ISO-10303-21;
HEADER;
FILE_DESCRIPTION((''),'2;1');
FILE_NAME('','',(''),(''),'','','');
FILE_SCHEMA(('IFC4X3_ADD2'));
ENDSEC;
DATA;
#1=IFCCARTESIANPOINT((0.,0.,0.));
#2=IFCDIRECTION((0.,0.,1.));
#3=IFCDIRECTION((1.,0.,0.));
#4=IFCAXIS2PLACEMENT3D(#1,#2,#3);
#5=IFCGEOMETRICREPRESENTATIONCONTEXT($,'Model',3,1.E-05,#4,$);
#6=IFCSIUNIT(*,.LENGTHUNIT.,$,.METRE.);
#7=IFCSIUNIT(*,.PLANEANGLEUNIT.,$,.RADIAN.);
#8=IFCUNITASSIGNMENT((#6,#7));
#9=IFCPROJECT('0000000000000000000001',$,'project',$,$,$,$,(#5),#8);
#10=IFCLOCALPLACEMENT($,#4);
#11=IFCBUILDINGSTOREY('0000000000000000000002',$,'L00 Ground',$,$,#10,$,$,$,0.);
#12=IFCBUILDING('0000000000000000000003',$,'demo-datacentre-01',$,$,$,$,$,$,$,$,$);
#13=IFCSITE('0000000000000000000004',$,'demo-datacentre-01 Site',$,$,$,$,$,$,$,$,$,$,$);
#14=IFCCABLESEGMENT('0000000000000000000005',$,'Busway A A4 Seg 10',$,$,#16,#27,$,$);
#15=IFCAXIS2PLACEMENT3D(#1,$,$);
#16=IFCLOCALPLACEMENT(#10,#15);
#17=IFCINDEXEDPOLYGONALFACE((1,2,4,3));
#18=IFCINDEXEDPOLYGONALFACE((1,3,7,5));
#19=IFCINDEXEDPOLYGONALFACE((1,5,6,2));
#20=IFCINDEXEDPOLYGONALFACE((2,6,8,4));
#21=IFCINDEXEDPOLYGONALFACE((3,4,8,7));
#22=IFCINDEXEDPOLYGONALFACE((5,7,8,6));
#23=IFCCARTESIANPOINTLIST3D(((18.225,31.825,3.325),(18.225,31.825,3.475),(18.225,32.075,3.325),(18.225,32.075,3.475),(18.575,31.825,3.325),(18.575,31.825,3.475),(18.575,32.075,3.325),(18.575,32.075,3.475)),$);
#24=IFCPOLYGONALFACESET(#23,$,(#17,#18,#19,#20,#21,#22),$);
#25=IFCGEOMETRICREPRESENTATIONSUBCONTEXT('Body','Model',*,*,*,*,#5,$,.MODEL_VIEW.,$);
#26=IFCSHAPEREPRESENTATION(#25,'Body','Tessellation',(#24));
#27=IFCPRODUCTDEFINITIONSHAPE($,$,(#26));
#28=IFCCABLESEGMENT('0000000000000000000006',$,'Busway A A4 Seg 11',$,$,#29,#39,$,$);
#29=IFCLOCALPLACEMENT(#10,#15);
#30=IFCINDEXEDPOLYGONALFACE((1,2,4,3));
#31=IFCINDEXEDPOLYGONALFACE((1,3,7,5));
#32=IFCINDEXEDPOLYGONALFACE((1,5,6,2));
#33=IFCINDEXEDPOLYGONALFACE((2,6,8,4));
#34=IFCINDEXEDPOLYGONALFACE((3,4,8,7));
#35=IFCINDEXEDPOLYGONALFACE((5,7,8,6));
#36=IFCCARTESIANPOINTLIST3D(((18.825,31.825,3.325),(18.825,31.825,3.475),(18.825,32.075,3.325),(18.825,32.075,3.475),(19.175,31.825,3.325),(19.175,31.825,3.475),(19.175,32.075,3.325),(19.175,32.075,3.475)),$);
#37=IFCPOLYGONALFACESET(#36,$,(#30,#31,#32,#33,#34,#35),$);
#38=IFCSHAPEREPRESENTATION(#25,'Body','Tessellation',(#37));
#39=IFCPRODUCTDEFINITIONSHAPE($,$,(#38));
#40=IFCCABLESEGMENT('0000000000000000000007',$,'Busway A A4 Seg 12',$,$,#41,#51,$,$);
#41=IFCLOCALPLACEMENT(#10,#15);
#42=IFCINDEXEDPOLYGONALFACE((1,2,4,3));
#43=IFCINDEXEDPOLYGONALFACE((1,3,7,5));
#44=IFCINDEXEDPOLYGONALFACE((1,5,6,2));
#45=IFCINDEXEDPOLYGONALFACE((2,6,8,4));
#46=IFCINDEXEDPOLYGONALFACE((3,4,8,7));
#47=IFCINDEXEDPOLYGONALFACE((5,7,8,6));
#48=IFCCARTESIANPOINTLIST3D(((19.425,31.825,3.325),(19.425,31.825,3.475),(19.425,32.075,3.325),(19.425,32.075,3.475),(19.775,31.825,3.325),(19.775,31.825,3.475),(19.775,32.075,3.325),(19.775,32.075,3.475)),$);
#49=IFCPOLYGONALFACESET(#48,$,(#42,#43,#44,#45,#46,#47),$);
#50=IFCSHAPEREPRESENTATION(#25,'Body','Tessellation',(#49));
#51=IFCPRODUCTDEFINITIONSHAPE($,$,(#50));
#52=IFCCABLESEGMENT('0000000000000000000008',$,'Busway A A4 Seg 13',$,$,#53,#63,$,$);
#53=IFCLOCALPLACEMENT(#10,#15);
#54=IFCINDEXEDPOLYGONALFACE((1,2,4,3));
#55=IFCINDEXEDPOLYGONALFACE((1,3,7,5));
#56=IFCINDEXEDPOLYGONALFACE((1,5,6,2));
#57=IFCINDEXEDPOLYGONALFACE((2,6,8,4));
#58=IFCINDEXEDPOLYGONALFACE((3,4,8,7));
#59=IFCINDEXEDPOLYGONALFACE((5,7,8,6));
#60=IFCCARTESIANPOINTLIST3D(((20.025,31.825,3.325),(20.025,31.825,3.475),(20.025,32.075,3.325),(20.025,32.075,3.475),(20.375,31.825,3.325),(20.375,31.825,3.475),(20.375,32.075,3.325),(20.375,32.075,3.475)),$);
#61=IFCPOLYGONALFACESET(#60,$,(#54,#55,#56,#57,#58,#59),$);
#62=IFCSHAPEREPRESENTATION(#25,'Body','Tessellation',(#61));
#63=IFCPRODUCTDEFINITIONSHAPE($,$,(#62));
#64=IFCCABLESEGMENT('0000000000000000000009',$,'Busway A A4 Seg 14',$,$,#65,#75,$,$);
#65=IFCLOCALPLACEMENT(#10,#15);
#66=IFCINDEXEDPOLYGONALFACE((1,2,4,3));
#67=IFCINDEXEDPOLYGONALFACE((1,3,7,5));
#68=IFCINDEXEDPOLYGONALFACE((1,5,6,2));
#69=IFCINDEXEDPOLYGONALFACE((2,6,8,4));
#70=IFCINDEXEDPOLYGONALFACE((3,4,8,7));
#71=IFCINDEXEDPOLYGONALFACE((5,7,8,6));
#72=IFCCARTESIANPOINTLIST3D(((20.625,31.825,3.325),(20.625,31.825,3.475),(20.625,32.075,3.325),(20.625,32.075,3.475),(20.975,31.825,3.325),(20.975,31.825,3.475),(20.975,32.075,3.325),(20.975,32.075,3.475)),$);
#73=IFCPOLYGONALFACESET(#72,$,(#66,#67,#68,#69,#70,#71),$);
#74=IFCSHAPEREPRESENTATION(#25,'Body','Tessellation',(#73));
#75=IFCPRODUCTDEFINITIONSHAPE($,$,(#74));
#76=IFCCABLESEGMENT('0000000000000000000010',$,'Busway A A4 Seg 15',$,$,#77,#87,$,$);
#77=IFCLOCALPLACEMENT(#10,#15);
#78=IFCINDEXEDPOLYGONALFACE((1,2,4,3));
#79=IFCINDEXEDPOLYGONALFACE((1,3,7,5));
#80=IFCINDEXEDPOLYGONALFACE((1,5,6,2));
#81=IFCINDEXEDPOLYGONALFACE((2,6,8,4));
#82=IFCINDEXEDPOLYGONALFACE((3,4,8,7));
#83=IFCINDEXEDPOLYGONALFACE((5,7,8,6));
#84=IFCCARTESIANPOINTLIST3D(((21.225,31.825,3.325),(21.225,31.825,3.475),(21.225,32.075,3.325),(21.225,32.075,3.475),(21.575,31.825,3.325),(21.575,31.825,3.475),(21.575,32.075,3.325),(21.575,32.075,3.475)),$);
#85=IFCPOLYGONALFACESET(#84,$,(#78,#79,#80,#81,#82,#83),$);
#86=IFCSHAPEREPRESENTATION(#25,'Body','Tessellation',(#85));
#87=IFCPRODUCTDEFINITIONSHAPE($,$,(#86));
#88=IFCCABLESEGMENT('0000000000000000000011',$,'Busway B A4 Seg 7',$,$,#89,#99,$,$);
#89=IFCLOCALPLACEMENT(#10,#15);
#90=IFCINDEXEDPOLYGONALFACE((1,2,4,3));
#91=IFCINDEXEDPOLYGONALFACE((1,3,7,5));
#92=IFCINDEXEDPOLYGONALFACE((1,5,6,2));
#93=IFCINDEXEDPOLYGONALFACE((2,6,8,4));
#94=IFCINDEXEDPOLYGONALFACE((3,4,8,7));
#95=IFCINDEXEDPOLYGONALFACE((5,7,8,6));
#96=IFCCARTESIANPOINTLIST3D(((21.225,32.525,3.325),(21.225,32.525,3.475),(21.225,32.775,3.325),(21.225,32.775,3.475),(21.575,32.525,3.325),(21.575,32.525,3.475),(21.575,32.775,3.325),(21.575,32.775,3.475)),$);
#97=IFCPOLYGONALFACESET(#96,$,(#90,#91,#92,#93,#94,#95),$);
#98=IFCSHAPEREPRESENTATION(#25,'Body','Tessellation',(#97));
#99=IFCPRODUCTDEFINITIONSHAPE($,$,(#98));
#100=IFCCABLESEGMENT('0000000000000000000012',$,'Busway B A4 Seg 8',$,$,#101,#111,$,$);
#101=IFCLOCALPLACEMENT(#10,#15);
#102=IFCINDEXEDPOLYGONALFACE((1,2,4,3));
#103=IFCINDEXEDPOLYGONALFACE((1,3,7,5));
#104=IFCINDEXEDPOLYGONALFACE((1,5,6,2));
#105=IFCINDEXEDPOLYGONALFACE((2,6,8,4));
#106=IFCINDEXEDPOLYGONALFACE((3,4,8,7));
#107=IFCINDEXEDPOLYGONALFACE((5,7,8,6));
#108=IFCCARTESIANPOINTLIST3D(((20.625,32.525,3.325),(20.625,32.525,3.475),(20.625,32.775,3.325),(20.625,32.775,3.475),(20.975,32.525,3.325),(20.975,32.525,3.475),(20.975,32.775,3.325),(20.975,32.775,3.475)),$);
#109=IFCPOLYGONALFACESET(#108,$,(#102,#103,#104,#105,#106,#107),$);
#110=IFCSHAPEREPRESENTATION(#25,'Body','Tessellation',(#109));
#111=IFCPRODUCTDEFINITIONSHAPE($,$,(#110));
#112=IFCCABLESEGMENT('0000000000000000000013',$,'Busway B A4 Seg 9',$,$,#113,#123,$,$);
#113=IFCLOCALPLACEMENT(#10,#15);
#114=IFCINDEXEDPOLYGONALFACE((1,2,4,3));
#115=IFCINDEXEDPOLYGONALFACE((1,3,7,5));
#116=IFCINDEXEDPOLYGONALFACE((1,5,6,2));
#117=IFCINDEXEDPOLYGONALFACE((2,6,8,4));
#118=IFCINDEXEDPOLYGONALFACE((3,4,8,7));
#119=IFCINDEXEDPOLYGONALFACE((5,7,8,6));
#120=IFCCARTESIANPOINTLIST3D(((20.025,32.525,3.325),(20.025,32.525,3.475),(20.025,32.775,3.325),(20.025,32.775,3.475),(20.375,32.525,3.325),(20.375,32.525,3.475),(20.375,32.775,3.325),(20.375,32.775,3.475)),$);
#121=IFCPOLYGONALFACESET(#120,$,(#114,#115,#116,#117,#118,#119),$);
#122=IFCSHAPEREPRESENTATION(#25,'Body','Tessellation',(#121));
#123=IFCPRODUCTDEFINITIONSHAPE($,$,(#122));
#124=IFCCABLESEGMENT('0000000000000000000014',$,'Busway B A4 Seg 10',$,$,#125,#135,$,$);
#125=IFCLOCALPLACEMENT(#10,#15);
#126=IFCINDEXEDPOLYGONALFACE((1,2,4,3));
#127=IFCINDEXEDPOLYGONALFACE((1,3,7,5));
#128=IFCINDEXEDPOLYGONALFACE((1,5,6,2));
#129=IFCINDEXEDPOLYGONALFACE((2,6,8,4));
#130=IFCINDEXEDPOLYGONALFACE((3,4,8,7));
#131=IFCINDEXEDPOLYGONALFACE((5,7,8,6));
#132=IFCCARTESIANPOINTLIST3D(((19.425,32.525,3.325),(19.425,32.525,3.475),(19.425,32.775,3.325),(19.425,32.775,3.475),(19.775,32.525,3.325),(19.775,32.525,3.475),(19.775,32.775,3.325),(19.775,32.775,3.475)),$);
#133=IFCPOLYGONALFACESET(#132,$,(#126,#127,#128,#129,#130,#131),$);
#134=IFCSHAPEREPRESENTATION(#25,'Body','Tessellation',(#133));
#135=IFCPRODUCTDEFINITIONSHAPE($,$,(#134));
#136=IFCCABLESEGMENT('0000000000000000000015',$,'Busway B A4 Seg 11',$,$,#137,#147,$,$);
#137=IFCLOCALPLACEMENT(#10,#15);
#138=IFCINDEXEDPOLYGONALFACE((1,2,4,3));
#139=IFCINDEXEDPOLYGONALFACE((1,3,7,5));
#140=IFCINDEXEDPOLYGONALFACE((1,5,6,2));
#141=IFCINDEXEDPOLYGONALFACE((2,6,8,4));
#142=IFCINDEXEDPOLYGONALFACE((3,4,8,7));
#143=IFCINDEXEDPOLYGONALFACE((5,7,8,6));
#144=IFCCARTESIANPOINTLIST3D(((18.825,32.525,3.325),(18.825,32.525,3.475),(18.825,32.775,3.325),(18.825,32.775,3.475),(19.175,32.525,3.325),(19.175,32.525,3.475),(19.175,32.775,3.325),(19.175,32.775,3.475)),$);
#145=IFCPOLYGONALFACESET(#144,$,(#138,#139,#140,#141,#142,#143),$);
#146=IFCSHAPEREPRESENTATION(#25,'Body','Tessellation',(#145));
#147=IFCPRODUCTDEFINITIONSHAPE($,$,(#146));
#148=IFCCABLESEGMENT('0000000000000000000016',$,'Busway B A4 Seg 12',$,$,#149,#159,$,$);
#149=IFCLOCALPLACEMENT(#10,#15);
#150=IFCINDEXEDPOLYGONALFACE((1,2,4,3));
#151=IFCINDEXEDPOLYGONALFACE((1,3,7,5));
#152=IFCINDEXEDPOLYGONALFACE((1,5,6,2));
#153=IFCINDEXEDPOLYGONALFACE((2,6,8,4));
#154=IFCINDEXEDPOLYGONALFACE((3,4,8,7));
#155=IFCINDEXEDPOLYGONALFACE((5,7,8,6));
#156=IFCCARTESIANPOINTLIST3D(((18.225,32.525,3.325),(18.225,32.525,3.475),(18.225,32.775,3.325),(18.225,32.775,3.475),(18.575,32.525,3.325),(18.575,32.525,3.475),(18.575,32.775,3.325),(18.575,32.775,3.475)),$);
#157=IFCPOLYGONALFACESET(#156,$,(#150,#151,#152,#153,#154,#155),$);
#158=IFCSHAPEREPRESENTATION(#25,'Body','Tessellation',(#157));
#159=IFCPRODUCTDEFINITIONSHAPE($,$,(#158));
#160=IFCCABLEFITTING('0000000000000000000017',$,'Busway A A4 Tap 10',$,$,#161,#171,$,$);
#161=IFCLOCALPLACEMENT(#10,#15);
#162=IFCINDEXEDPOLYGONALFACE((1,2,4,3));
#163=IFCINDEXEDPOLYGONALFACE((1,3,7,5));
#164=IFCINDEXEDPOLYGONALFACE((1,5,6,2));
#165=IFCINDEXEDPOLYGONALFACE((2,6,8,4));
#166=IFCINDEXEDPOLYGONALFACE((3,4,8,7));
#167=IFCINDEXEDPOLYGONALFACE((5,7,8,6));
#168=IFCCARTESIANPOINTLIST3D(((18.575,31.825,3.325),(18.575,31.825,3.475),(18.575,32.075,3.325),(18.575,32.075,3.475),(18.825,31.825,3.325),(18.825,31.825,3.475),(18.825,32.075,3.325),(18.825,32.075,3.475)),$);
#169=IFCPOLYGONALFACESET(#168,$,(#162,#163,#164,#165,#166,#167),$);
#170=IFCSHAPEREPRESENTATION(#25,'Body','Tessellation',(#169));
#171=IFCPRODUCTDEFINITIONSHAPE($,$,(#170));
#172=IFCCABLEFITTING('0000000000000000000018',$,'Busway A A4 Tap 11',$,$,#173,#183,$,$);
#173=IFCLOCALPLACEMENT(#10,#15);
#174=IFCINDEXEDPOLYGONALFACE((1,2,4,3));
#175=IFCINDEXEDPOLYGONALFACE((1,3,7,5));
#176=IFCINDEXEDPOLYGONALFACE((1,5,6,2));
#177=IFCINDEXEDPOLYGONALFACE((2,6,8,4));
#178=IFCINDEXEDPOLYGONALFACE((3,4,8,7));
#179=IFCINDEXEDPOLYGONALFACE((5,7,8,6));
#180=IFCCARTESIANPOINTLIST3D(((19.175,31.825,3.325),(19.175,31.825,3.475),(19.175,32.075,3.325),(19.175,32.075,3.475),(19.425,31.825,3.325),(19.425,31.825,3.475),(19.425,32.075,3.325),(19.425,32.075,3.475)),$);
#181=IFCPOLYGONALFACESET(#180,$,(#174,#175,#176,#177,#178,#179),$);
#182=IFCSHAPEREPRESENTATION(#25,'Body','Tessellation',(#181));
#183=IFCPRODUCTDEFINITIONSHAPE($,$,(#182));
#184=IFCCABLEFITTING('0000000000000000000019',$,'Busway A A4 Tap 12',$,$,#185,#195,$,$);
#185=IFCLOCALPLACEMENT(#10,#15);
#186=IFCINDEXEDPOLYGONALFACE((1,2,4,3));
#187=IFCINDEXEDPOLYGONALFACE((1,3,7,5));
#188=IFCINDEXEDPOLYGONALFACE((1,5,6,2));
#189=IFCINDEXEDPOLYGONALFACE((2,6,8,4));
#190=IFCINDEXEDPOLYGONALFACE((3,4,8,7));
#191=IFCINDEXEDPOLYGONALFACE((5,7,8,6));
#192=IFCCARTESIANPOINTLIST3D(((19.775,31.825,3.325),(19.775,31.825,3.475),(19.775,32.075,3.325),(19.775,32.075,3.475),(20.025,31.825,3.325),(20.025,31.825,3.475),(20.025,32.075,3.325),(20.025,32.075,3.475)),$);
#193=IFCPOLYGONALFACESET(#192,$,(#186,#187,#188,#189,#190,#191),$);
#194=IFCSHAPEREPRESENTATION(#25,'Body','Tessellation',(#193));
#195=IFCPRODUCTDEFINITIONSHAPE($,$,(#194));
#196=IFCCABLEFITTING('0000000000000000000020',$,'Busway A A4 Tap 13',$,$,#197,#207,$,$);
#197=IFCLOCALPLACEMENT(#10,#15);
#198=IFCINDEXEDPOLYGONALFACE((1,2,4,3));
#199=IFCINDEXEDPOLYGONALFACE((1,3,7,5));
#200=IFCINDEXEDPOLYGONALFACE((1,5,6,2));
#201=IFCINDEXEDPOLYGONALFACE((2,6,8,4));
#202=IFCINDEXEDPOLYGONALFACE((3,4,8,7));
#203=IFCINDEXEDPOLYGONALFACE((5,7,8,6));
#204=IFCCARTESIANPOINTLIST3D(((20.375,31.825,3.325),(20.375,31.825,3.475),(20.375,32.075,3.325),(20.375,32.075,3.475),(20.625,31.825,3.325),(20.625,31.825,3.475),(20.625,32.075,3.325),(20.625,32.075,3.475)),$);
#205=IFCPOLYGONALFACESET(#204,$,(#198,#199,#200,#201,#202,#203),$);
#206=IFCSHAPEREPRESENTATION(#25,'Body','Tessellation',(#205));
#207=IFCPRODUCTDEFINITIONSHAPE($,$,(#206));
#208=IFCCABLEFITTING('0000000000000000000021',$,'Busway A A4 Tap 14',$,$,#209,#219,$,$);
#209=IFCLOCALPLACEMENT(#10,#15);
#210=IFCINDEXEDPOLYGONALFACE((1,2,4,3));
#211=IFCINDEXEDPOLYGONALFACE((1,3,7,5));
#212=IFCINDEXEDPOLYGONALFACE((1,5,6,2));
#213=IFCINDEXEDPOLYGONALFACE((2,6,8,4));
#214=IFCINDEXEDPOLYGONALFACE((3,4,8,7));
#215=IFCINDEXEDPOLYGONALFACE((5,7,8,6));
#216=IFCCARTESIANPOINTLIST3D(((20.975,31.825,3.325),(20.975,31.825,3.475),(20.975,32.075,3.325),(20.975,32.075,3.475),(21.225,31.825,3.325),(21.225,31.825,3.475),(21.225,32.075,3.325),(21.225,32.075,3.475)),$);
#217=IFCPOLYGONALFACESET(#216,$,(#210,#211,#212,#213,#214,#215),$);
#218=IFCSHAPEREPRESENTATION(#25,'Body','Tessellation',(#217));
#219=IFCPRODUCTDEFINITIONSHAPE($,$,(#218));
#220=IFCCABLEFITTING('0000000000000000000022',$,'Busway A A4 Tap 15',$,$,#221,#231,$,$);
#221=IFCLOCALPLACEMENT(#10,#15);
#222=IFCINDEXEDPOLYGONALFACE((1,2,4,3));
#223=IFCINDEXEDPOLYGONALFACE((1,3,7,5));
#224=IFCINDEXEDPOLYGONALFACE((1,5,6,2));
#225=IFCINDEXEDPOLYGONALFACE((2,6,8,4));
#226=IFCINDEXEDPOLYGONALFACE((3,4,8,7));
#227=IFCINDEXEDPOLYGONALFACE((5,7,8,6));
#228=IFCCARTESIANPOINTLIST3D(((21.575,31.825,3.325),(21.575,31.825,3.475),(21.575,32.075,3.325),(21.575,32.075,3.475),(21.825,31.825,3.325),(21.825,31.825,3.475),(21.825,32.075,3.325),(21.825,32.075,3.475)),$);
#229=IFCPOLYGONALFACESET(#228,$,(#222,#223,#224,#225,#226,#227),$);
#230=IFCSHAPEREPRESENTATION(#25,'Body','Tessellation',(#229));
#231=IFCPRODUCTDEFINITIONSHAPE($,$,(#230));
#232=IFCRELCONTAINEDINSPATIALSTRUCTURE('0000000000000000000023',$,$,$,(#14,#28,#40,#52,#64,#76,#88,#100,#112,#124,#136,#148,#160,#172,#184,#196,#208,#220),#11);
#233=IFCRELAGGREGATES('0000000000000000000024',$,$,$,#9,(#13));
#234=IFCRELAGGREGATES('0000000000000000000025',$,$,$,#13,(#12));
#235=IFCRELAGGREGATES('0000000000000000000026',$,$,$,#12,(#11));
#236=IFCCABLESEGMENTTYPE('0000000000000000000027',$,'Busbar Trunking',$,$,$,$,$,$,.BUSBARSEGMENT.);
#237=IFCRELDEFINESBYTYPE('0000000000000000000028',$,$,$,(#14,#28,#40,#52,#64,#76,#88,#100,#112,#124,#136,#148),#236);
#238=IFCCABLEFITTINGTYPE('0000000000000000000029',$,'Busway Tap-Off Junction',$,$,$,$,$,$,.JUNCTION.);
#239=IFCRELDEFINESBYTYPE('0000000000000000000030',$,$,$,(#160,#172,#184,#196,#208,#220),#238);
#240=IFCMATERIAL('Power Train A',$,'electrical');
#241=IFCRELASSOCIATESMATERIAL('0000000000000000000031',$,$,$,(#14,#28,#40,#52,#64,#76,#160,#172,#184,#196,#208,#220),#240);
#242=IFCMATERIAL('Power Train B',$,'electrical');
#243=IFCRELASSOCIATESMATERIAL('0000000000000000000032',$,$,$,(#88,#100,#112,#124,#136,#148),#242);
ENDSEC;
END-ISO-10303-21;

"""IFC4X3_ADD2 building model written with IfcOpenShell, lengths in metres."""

from ifc_helpers import new_model, si_unit, frame, origin_with_axes, place, context, subcontext, project, spatial, rectangle, extrude, material, type_object, element, save


model = new_model("IFC4X3_ADD2")

# Units and contexts
model_context = context("Model", 3, precision=1e-05, world=origin_with_axes())
body_context = subcontext(model_context, "Body", "Model", "MODEL_VIEW")
ifc_project = project(units=[si_unit("LENGTHUNIT", "METRE"), si_unit("PLANEANGLEUNIT", "RADIAN")], contexts=[model_context])

# Site, building, storey
site = spatial("IfcSite", under=ifc_project, Name="demo-datacentre-01 Site")
building = spatial("IfcBuilding", under=site, Name="demo-datacentre-01")
storey_placement = place(None, origin_with_axes())
storey = spatial("IfcBuildingStorey", under=building, at=storey_placement, Name="L00 Ground", Elevation=0.0)

# Cable segments
ifc_material_1 = material(Name="Power Train A", Category="electrical")
cable_segment_type_1 = type_object("IfcCableSegmentType", Name="Busbar Trunking", PredefinedType="BUSBARSEGMENT")
cable_segment_1_placement = place(storey_placement, frame((18.225, 31.95, 3.4), z_axis=(1.0, 0.0, 0.0), x_axis=(0.0, 1.0, 0.0)))
element("IfcCableSegment", 1, at=cable_segment_1_placement, inside=storey, type_object=cable_segment_type_1, material=ifc_material_1, Name="Busway A A4 Seg 10", context=body_context, shape_type="SweptSolid", body=[
    extrude(rectangle(XDim=0.25, YDim=0.15), origin_with_axes(), (0.0, 0.0, 1.0), 0.35),
])
cable_segment_2_placement = place(storey_placement, frame((18.825, 31.95, 3.4), z_axis=(1.0, 0.0, 0.0), x_axis=(0.0, 1.0, 0.0)))
element("IfcCableSegment", 2, at=cable_segment_2_placement, inside=storey, type_object=cable_segment_type_1, material=ifc_material_1, Name="Busway A A4 Seg 11", context=body_context, shape_type="SweptSolid", body=[
    extrude(rectangle(XDim=0.25, YDim=0.15), origin_with_axes(), (0.0, 0.0, 1.0), 0.35),
])
cable_segment_3_placement = place(storey_placement, frame((19.425, 31.95, 3.4), z_axis=(1.0, 0.0, 0.0), x_axis=(0.0, 1.0, 0.0)))
element("IfcCableSegment", 3, at=cable_segment_3_placement, inside=storey, type_object=cable_segment_type_1, material=ifc_material_1, Name="Busway A A4 Seg 12", context=body_context, shape_type="SweptSolid", body=[
    extrude(rectangle(XDim=0.25, YDim=0.15), origin_with_axes(), (0.0, 0.0, 1.0), 0.35),
])
for number, where, z_axis, x_axis, name in (
    (4, (20.025, 31.95, 3.4), (1.0, 0.0, 0.0), (0.0, 1.0, 0.0), "Busway A A4 Seg 13"),
    (5, (20.625, 31.95, 3.4), (1.0, 0.0, 0.0), (0.0, 1.0, 0.0), "Busway A A4 Seg 14"),
    (6, (21.225, 31.95, 3.4), (1.0, 0.0, 0.0), (0.0, 1.0, 0.0), "Busway A A4 Seg 15"),
):
    element("IfcCableSegment", number, at=place(storey_placement, frame(where, z_axis=z_axis, x_axis=x_axis)), inside=storey, type_object=cable_segment_type_1, material=ifc_material_1, Name=name, context=body_context, shape_type="SweptSolid", body=[
        extrude(rectangle(XDim=0.25, YDim=0.15), origin_with_axes(), (0.0, 0.0, 1.0), 0.35),
    ])
ifc_material_2 = material(Name="Power Train B", Category="electrical")
for number, where, z_axis, x_axis, name in (
    (7, (21.575, 32.65, 3.4), (-1.0, 0.0, 0.0), (0.0, -1.0, 0.0), "Busway B A4 Seg 7"),
    (8, (20.975, 32.65, 3.4), (-1.0, 0.0, 0.0), (0.0, -1.0, 0.0), "Busway B A4 Seg 8"),
    (9, (20.375, 32.65, 3.4), (-1.0, 0.0, 0.0), (0.0, -1.0, 0.0), "Busway B A4 Seg 9"),
):
    element("IfcCableSegment", number, at=place(storey_placement, frame(where, z_axis=z_axis, x_axis=x_axis)), inside=storey, type_object=cable_segment_type_1, material=ifc_material_2, Name=name, context=body_context, shape_type="SweptSolid", body=[
        extrude(rectangle(XDim=0.25, YDim=0.15), origin_with_axes(), (0.0, 0.0, 1.0), 0.35),
    ])
cable_segment_4_placement = place(storey_placement, frame((19.775, 32.65, 3.4), z_axis=(-1.0, 0.0, 0.0), x_axis=(0.0, -1.0, 0.0)))
element("IfcCableSegment", 10, at=cable_segment_4_placement, inside=storey, type_object=cable_segment_type_1, material=ifc_material_2, Name="Busway B A4 Seg 10", context=body_context, shape_type="SweptSolid", body=[
    extrude(rectangle(XDim=0.25, YDim=0.15), origin_with_axes(), (0.0, 0.0, 1.0), 0.35),
])
cable_segment_5_placement = place(storey_placement, frame((19.175, 32.65, 3.4), z_axis=(-1.0, 0.0, 0.0), x_axis=(0.0, -1.0, 0.0)))
element("IfcCableSegment", 11, at=cable_segment_5_placement, inside=storey, type_object=cable_segment_type_1, material=ifc_material_2, Name="Busway B A4 Seg 11", context=body_context, shape_type="SweptSolid", body=[
    extrude(rectangle(XDim=0.25, YDim=0.15), origin_with_axes(), (0.0, 0.0, 1.0), 0.35),
])
cable_segment_6_placement = place(storey_placement, frame((18.575, 32.65, 3.4), z_axis=(-1.0, 0.0, 0.0), x_axis=(0.0, -1.0, 0.0)))
element("IfcCableSegment", 12, at=cable_segment_6_placement, inside=storey, type_object=cable_segment_type_1, material=ifc_material_2, Name="Busway B A4 Seg 12", context=body_context, shape_type="SweptSolid", body=[
    extrude(rectangle(XDim=0.25, YDim=0.15), origin_with_axes(), (0.0, 0.0, 1.0), 0.35),
])

# Cable fittings
cable_fitting_type = type_object("IfcCableFittingType", Name="Busway Tap-Off Junction", PredefinedType="JUNCTION")
for number, where, z_axis, x_axis, name in (
    (13, (18.7, 31.95, 3.325), (0.0, 0.0, 1.0), (1.0, 0.0, 0.0), "Busway A A4 Tap 10"),
    (14, (19.3, 31.95, 3.325), (0.0, 0.0, 1.0), (1.0, 0.0, 0.0), "Busway A A4 Tap 11"),
    (15, (19.9, 31.95, 3.325), (0.0, 0.0, 1.0), (1.0, 0.0, 0.0), "Busway A A4 Tap 12"),
    (16, (20.5, 31.95, 3.325), (0.0, 0.0, 1.0), (1.0, 0.0, 0.0), "Busway A A4 Tap 13"),
    (17, (21.1, 31.95, 3.325), (0.0, 0.0, 1.0), (1.0, 0.0, 0.0), "Busway A A4 Tap 14"),
    (18, (21.7, 31.95, 3.325), (0.0, 0.0, 1.0), (1.0, 0.0, 0.0), "Busway A A4 Tap 15"),
):
    element("IfcCableFitting", number, at=place(storey_placement, frame(where, z_axis=z_axis, x_axis=x_axis)), inside=storey, type_object=cable_fitting_type, material=ifc_material_1, Name=name, context=body_context, shape_type="SweptSolid", body=[
        extrude(rectangle(XDim=0.25, YDim=0.25), origin_with_axes(), (0.0, 0.0, 1.0), 0.15),
    ])

save(model, "model.ifc")
